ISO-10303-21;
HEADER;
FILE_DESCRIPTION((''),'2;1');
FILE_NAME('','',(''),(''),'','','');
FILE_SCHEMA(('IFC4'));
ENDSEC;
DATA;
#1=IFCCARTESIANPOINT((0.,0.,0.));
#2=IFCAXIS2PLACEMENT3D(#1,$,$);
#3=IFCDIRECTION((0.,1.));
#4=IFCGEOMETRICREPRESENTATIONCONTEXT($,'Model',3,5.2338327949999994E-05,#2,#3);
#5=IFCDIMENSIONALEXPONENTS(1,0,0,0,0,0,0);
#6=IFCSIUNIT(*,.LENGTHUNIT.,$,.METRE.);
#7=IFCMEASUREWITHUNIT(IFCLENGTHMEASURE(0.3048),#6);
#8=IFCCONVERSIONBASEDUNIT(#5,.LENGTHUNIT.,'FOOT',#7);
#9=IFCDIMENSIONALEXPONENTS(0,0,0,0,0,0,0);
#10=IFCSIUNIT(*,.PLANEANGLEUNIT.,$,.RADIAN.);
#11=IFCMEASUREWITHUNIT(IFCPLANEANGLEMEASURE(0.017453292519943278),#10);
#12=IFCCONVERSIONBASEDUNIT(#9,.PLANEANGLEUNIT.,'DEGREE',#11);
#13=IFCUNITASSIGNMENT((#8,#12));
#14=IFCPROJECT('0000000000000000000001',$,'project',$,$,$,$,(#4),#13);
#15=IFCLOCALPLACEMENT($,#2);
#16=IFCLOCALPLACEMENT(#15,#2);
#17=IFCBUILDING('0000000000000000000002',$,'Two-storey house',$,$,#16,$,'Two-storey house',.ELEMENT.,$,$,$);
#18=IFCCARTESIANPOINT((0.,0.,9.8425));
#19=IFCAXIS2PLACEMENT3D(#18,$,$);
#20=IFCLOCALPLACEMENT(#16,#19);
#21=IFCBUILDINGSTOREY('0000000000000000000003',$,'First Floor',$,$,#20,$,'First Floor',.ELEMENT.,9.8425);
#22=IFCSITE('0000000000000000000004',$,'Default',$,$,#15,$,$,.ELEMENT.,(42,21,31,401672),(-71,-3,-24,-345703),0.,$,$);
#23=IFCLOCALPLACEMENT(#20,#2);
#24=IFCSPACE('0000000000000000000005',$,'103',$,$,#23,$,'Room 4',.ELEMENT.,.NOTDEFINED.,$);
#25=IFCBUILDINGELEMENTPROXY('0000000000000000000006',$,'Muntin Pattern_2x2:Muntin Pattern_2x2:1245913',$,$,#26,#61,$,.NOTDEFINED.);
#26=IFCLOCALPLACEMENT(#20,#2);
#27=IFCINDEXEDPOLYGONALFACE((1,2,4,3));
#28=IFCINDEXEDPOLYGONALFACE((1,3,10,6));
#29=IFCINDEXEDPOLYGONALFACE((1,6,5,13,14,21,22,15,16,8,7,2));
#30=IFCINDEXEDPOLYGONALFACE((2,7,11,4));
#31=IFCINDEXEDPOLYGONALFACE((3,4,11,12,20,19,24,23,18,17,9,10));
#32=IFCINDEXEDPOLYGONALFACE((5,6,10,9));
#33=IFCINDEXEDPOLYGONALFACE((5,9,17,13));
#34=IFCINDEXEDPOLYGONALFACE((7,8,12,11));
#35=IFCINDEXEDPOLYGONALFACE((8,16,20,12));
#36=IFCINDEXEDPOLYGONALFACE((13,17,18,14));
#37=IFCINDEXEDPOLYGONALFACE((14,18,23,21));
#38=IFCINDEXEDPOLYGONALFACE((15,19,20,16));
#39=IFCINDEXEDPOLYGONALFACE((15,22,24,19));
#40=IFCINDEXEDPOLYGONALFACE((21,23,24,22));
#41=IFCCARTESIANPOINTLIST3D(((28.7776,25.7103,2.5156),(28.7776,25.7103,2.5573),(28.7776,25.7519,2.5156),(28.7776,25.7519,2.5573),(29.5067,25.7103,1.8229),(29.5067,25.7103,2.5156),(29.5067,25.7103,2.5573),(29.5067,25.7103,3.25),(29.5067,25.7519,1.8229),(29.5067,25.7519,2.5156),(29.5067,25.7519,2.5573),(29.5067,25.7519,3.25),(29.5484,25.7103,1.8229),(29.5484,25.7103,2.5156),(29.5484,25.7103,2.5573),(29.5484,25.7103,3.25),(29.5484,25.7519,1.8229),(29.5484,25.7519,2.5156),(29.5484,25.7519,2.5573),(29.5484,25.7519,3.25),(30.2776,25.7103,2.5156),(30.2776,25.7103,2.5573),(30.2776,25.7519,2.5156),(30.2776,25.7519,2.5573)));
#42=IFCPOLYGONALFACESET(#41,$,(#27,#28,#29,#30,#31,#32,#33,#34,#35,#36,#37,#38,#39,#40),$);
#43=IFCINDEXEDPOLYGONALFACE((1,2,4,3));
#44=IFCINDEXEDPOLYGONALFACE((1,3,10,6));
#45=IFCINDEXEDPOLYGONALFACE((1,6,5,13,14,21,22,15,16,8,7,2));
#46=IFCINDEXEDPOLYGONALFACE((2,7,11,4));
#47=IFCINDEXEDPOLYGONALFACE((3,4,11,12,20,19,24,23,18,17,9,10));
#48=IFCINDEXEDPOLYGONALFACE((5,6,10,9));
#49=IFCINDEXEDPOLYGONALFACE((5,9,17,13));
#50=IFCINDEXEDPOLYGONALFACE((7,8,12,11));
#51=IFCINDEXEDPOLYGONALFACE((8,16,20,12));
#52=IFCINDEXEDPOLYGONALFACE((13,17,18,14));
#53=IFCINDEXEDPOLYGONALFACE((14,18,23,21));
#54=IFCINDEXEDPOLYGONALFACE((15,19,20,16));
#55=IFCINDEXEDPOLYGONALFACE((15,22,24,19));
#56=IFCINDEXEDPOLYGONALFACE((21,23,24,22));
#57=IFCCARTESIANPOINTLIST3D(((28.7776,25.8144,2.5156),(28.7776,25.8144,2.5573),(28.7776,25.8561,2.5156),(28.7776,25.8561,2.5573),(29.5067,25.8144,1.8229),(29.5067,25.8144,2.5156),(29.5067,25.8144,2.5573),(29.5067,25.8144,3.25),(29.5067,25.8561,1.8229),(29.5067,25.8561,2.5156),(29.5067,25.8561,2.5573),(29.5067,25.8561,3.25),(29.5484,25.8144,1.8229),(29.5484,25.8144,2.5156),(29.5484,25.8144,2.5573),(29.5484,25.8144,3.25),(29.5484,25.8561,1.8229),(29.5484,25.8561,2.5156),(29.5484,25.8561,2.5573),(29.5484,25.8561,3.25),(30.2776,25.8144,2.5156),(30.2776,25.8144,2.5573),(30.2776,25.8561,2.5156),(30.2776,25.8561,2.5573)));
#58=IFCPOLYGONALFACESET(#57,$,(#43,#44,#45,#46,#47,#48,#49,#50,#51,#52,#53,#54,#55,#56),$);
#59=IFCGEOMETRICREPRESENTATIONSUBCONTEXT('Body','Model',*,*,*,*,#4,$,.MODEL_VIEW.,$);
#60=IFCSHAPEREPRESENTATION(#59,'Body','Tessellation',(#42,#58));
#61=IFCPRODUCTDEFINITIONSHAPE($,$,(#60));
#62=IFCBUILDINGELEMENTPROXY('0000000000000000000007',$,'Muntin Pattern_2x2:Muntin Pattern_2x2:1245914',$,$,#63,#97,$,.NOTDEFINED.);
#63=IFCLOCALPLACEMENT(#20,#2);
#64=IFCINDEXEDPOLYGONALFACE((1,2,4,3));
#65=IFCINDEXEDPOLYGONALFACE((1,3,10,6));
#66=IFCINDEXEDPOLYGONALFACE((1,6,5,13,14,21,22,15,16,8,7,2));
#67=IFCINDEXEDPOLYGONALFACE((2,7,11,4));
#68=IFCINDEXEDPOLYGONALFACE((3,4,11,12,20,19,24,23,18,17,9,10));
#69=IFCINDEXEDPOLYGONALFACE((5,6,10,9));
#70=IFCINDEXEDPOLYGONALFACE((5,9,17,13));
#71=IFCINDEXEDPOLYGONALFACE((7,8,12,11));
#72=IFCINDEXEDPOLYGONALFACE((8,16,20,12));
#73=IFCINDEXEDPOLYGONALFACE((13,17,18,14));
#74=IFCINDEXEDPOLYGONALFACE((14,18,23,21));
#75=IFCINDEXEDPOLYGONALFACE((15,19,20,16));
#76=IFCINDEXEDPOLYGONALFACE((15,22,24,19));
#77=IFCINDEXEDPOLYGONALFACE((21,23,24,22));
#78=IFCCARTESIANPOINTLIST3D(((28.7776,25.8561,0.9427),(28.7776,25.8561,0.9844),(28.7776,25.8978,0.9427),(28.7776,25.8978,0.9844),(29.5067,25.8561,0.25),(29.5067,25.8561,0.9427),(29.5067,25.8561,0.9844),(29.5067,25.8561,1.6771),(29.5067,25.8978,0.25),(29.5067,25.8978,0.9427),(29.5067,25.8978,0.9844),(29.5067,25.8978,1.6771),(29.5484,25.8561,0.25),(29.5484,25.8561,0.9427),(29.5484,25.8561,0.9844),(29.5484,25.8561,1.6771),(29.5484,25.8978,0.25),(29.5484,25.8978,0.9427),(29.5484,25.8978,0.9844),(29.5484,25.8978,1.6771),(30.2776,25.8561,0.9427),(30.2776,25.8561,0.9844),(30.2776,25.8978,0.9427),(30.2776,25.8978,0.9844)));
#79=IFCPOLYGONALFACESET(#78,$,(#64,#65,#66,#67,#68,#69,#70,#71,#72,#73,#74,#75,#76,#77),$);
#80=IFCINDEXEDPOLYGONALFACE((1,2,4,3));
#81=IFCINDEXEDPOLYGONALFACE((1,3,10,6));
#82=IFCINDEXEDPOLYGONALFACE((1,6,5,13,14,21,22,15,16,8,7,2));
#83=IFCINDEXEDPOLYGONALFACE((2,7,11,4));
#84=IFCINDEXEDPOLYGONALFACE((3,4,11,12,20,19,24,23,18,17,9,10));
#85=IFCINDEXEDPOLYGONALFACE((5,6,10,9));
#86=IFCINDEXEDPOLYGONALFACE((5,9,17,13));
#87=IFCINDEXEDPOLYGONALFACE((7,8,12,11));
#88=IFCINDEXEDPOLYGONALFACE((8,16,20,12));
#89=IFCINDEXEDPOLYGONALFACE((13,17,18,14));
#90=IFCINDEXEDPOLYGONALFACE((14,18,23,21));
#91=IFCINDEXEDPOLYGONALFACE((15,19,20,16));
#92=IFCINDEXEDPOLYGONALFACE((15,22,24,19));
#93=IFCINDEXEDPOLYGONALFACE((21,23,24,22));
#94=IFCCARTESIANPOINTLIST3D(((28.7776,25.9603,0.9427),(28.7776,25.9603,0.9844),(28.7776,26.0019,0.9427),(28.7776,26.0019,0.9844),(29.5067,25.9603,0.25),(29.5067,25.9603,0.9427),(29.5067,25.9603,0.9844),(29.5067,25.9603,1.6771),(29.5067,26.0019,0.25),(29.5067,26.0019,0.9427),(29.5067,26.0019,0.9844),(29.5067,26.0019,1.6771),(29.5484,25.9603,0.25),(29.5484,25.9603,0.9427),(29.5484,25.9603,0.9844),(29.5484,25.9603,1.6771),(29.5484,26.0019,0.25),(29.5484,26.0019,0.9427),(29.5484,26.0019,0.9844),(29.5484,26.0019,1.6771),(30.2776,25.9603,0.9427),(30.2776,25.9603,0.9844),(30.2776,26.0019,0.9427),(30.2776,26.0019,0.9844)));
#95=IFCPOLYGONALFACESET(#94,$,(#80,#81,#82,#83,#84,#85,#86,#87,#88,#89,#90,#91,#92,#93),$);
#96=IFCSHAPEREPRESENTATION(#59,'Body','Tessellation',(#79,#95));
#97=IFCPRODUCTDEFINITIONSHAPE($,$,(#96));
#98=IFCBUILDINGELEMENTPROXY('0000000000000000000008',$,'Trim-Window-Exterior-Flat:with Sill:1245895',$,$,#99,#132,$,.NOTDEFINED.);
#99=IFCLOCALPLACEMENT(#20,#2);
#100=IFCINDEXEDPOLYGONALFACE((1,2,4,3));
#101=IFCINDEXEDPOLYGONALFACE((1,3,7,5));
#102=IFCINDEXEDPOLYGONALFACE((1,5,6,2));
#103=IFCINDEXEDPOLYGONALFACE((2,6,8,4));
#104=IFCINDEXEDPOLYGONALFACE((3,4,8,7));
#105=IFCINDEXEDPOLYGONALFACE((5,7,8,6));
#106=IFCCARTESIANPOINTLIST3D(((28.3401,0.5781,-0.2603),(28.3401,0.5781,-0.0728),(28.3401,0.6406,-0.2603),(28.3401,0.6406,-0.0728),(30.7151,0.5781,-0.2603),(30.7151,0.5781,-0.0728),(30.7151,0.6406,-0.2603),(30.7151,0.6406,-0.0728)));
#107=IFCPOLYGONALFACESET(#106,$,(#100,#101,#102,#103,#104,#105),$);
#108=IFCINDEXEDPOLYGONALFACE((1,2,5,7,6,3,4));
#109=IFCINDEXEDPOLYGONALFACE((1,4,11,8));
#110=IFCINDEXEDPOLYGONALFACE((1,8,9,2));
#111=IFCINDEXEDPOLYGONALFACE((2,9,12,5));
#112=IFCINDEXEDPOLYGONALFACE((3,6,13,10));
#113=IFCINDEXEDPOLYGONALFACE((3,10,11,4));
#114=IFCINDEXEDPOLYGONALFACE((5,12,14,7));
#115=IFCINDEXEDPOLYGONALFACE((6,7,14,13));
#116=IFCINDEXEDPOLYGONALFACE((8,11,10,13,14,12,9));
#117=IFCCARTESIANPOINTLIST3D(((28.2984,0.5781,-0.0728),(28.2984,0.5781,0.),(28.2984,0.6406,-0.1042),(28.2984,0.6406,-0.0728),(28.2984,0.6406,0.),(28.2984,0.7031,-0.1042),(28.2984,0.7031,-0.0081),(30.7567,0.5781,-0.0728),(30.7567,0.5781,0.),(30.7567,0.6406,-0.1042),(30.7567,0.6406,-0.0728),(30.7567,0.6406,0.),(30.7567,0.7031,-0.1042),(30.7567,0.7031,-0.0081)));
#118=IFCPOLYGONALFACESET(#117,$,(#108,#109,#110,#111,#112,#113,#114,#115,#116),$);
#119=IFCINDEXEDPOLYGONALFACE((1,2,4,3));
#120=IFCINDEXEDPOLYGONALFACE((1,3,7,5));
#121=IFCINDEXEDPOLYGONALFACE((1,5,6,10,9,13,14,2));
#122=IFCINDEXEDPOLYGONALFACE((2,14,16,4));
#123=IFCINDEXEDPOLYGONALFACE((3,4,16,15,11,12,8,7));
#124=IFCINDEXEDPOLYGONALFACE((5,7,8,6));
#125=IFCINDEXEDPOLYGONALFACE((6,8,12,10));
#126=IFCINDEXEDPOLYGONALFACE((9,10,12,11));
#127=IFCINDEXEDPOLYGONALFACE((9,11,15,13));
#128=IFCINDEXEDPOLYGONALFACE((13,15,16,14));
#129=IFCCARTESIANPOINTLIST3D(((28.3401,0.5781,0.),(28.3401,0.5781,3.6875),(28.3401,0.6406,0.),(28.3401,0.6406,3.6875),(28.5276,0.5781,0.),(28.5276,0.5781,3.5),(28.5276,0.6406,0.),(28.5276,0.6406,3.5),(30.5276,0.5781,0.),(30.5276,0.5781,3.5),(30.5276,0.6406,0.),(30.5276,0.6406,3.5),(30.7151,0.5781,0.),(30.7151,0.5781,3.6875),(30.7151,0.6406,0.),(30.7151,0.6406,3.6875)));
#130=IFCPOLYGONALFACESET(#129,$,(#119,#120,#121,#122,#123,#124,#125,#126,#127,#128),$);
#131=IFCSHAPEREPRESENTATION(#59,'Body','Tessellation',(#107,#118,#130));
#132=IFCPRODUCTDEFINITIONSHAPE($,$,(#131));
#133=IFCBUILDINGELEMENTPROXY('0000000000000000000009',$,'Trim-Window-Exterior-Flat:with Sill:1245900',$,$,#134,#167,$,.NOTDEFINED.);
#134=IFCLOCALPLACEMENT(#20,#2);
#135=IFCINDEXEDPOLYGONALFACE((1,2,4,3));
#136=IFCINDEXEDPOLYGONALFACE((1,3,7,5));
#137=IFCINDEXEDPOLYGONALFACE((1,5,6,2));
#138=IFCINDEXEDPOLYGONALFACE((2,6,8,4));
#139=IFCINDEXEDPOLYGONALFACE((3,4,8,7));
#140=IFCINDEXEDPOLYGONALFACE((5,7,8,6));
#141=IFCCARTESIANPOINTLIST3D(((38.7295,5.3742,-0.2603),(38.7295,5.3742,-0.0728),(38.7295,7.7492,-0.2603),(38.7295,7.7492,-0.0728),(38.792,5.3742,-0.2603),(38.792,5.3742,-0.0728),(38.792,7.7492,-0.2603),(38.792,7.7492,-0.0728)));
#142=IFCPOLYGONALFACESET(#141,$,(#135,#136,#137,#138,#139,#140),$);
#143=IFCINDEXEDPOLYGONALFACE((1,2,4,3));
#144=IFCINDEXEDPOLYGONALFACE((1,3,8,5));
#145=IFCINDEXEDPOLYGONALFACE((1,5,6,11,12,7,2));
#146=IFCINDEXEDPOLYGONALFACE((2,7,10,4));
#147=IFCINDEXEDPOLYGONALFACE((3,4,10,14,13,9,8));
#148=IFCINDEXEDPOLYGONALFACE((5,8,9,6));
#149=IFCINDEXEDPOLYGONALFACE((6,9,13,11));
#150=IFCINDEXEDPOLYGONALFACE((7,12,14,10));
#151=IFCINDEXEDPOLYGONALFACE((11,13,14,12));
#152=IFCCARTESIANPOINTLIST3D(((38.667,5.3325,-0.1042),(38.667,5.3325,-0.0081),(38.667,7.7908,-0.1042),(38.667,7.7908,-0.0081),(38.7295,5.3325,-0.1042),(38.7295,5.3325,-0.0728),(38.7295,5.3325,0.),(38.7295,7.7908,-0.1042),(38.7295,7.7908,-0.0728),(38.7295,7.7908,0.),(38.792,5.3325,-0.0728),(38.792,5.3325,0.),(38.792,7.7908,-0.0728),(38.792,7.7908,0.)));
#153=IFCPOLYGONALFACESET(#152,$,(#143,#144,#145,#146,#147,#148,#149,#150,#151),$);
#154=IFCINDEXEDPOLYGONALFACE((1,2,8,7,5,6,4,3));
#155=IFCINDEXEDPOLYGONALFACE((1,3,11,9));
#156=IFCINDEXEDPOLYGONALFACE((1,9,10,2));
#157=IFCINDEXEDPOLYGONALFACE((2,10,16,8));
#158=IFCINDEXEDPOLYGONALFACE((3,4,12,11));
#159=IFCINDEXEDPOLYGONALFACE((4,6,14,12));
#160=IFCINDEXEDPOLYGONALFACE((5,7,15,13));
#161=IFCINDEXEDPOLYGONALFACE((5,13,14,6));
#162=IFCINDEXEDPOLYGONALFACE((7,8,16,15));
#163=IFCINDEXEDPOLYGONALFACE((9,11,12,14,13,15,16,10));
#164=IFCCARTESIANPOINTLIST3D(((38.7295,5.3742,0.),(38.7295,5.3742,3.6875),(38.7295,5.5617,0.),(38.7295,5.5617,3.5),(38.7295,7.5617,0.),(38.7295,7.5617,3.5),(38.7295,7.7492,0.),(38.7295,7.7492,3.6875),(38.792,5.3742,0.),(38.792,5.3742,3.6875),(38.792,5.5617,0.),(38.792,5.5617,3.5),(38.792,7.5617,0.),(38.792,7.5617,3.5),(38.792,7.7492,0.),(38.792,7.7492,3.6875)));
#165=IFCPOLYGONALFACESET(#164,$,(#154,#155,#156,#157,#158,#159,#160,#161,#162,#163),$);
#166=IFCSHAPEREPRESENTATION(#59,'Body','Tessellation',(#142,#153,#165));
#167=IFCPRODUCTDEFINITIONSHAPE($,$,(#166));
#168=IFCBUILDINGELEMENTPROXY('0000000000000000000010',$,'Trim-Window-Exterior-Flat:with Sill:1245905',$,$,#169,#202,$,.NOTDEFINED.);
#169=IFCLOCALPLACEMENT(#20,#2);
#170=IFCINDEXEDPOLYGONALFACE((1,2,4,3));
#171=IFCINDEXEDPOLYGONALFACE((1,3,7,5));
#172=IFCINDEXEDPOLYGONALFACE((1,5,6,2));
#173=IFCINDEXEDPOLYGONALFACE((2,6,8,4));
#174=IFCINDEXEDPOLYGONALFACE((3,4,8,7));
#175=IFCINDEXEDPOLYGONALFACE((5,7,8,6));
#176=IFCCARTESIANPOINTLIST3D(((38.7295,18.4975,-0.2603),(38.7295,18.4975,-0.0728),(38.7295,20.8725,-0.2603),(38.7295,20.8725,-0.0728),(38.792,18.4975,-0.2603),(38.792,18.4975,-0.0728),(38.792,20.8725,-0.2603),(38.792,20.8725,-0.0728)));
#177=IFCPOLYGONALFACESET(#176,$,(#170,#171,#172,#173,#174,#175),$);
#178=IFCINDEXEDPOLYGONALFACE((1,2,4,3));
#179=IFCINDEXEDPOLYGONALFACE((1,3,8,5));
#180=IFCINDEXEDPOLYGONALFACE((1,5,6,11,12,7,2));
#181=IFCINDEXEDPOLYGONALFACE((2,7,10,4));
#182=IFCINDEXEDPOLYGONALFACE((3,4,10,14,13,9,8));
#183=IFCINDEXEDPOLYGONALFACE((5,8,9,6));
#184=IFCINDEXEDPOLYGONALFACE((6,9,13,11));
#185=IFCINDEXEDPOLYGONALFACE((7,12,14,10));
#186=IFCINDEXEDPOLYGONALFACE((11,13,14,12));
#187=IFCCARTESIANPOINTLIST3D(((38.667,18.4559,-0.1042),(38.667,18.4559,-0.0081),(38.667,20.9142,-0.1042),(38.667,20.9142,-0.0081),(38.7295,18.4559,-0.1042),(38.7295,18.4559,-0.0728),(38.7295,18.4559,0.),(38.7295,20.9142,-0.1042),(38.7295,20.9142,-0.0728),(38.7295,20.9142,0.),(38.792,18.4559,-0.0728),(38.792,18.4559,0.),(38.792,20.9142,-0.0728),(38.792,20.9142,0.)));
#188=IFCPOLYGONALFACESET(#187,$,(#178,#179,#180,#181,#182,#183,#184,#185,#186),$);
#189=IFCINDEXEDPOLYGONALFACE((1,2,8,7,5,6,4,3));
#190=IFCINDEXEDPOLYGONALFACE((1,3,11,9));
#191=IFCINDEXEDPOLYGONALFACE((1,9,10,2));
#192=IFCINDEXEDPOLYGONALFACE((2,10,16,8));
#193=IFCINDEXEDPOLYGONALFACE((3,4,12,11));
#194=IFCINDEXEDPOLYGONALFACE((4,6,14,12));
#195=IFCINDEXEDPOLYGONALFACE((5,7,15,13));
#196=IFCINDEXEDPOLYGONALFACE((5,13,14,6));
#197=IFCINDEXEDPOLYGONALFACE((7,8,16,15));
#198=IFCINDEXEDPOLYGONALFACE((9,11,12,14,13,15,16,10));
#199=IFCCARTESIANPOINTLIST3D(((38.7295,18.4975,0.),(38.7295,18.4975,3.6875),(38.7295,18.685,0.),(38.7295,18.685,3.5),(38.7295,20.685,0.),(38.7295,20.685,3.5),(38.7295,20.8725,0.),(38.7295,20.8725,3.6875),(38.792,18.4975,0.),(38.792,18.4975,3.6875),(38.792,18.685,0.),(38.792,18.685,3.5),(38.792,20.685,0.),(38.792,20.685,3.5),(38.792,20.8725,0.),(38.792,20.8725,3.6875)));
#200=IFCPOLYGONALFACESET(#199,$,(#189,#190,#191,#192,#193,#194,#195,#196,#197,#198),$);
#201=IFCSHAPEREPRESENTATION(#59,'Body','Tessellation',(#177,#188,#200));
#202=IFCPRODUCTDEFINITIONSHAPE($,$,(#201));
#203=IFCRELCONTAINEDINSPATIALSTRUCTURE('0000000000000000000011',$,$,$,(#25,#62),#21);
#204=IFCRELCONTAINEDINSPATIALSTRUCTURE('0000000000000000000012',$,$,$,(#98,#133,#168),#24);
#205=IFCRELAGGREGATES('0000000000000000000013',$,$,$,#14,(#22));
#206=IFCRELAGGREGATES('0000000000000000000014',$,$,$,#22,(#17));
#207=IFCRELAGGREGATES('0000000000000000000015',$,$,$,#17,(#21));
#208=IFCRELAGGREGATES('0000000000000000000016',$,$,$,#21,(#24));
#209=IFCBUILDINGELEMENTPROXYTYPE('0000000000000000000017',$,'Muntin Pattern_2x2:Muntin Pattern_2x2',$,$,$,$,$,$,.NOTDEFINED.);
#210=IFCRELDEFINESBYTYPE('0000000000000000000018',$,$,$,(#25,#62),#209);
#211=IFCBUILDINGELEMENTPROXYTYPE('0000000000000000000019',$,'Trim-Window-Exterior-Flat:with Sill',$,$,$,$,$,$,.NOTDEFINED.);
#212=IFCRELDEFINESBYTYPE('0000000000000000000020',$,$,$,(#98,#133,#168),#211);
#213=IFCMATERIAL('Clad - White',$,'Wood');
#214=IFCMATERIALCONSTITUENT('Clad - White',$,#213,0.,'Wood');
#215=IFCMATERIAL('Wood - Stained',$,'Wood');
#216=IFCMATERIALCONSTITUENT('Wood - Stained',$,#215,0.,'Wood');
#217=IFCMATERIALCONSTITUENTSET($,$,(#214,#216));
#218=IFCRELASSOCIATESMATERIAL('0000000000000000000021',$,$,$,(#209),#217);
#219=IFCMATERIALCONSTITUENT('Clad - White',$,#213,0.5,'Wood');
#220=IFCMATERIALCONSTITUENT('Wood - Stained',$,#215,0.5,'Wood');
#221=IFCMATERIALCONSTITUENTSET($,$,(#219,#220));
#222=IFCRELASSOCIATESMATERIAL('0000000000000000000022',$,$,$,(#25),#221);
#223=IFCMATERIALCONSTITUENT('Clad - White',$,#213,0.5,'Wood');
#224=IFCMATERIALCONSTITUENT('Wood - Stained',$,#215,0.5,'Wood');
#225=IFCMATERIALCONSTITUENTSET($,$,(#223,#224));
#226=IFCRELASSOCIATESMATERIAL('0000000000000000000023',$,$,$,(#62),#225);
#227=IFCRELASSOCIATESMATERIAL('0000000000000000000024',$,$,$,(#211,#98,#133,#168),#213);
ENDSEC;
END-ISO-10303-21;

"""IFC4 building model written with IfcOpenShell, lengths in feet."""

from ifc_helpers import new_model, entity, si_unit, converted_unit, direction, frame, origin, place, context, subcontext, project, spatial, indexed_curve, outline, extrude, source, transform, mapped, material, constituent, constituent_set, type_object, type_shapes, element, save


model = new_model("IFC4")

# Units and contexts
model_context = context("Model", 3, precision=5.2338327949999994e-05, world=origin(), true_north=direction((0.0, 1.0)))
body_context = subcontext(model_context, "Body", "Model", "MODEL_VIEW")
ifc_project = project(units=[converted_unit("LENGTHUNIT", "FOOT", entity("IfcLengthMeasure", 0.3048), si_unit("LENGTHUNIT", "METRE"), dimensions=[1, 0, 0, 0, 0, 0, 0]), converted_unit("PLANEANGLEUNIT", "DEGREE", entity("IfcPlaneAngleMeasure", 0.017453292519943278), si_unit("PLANEANGLEUNIT", "RADIAN"), dimensions=[0, 0, 0, 0, 0, 0, 0])], contexts=[model_context])

# Site, building, storey
site_placement = place(None, origin())
site = spatial("IfcSite", under=ifc_project, at=site_placement, Name="Default", CompositionType="ELEMENT", RefLatitude=(42, 21, 31, 401672), RefLongitude=(-71, -3, -24, -345703), RefElevation=0.0)
building_placement = place(site_placement, origin())
building = spatial("IfcBuilding", under=site, at=building_placement, Name="Two-storey house", LongName="Two-storey house", CompositionType="ELEMENT")
storey_placement = place(building_placement, frame((0.0, 0.0, 9.8425)))
storey = spatial("IfcBuildingStorey", under=building, at=storey_placement, Name="First Floor", LongName="First Floor", CompositionType="ELEMENT", Elevation=9.8425)

# Shared definitions
ifc_material_1 = material(Name="Wood - Stained", Category="Wood")

# Building element proxies
ifc_material_2 = material(Name="Clad - White", Category="Wood")
ifc_constituent_1 = constituent(ifc_material_2, Name="Clad - White", Category="Wood", fraction=0.0)
ifc_constituent_2 = constituent(ifc_material_1, Name="Wood - Stained", Category="Wood", fraction=0.0)
ifc_constituent_set_1 = constituent_set(constituents=[ifc_constituent_1, ifc_constituent_2])
building_element_proxy_type_1 = type_object("IfcBuildingElementProxyType", Name="Muntin Pattern_2x2:Muntin Pattern_2x2", PredefinedType="NOTDEFINED", material=ifc_constituent_set_1)
shared_shape_1 = source(origin(), body_context, "Body", "SweptSolid", [
    extrude(outline(indexed_curve([(0.0208, -0.0208), (0.7135, -0.0208), (0.7135, 0.0208), (0.0208, 0.0208), (0.0208, 0.75), (-0.0208, 0.75), (-0.0208, 0.0208), (-0.7135, 0.0208), (-0.7135, -0.0208), (-0.0208, -0.0208), (-0.0208, -0.75), (0.0208, -0.75), (0.0208, -0.0208)], self_intersect=False)), frame((0.0, 0.0312, 0.7135), z_axis=(0.0, 1.0, 0.0), x_axis=(0.0, 0.0, 1.0)), (0.0, 0.0, 1.0), 0.0417),
    extrude(outline(indexed_curve([(0.0208, -0.0208), (0.7135, -0.0208), (0.7135, 0.0208), (0.0208, 0.0208), (0.0208, 0.75), (-0.0208, 0.75), (-0.0208, 0.0208), (-0.7135, 0.0208), (-0.7135, -0.0208), (-0.0208, -0.0208), (-0.0208, -0.75), (0.0208, -0.75), (0.0208, -0.0208)], self_intersect=False)), frame((0.0, -0.0729, 0.7135), z_axis=(0.0, 1.0, 0.0), x_axis=(0.0, 0.0, 1.0)), (0.0, 0.0, 1.0), 0.0417),
])
type_shapes(building_element_proxy_type_1, [shared_shape_1])
ifc_constituent_3 = constituent(ifc_material_2, Name="Clad - White", Category="Wood", fraction=0.5)
ifc_constituent_4 = constituent(ifc_material_1, Name="Wood - Stained", Category="Wood", fraction=0.5)
ifc_constituent_set_2 = constituent_set(constituents=[ifc_constituent_3, ifc_constituent_4])
proxy_1_placement = place(storey_placement, frame((29.5276, 25.7832, 1.8229), z_axis=(0.0, 0.0, 1.0), x_axis=(-1.0, 0.0, 0.0)))
element("IfcBuildingElementProxy", 1, at=proxy_1_placement, inside=storey, type_object=building_element_proxy_type_1, material=ifc_constituent_set_2, Name="Muntin Pattern_2x2:Muntin Pattern_2x2:1245913", PredefinedType="NOTDEFINED", context=body_context, shape_type="MappedRepresentation", body=[
    mapped(shared_shape_1, transform((0.0, 0.0, 0.0), scale=1.0)),
])
ifc_constituent_5 = constituent(ifc_material_2, Name="Clad - White", Category="Wood", fraction=0.5)
ifc_constituent_6 = constituent(ifc_material_1, Name="Wood - Stained", Category="Wood", fraction=0.5)
ifc_constituent_set_3 = constituent_set(constituents=[ifc_constituent_5, ifc_constituent_6])
proxy_2_placement = place(storey_placement, frame((29.5276, 25.929, 0.25), z_axis=(0.0, 0.0, 1.0), x_axis=(-1.0, 0.0, 0.0)))
element("IfcBuildingElementProxy", 2, at=proxy_2_placement, inside=storey, type_object=building_element_proxy_type_1, material=ifc_constituent_set_3, Name="Muntin Pattern_2x2:Muntin Pattern_2x2:1245914", PredefinedType="NOTDEFINED", context=body_context, shape_type="MappedRepresentation", body=[
    mapped(shared_shape_1, transform((0.0, 0.0, 0.0), scale=1.0)),
])

# Shared definitions
space_placement = place(storey_placement, origin())
space = spatial("IfcSpace", under=storey, at=space_placement, Name="103", LongName="Room 4", CompositionType="ELEMENT", PredefinedType="NOTDEFINED")

# Building element proxies
building_element_proxy_type_2 = type_object("IfcBuildingElementProxyType", Name="Trim-Window-Exterior-Flat:with Sill", PredefinedType="NOTDEFINED", material=ifc_material_2)
shared_shape_2 = source(origin(), body_context, "Body", "SweptSolid", [
    extrude(outline(indexed_curve([(-1.1875, -0.0938), (1.1875, -0.0938), (1.1875, 0.0938), (-1.1875, 0.0938), (-1.1875, -0.0938)], self_intersect=False)), frame((0.0, -3.6665, 0.0), z_axis=(0.0, 0.0, 1.0), x_axis=(-1.0, 0.0, 0.0)), (0.0, 0.0, 1.0), 0.0625),
    extrude(outline(indexed_curve([(-0.0625, -0.0525), (0.0, -0.0525), (0.0, -0.0211), (0.0625, -0.0211), (0.0625, 0.0517), (0.0, 0.0517), (-0.0625, 0.0436), (-0.0625, -0.0525)], self_intersect=False)), frame((-1.2292, -3.5517, 0.0625), z_axis=(1.0, 0.0, 0.0), x_axis=(0.0, 0.0, -1.0)), (0.0, 0.0, 1.0), 2.4583),
    extrude(outline(indexed_curve([(-1.8906, -1.1875), (1.7969, -1.1875), (1.7969, -1.0), (-1.7031, -1.0), (-1.7031, 1.0), (1.7969, 1.0), (1.7969, 1.1875), (-1.8906, 1.1875), (-1.8906, -1.1875)], self_intersect=False)), frame((0.0, -1.7031, 0.0), z_axis=(0.0, 0.0, 1.0), x_axis=(0.0, -1.0, 0.0)), (0.0, 0.0, 1.0), 0.0625),
])
type_shapes(building_element_proxy_type_2, [shared_shape_2])
for number, where, z_axis, x_axis, name in (
    (3, (29.5276, 0.5781, 3.5), (0.0, 1.0, 0.0), (-1.0, 0.0, 0.0), "Trim-Window-Exterior-Flat:with Sill:1245895"),
    (4, (38.792, 6.5617, 3.5), (-1.0, 0.0, 0.0), (0.0, -1.0, 0.0), "Trim-Window-Exterior-Flat:with Sill:1245900"),
    (5, (38.792, 19.685, 3.5), (-1.0, 0.0, 0.0), (0.0, -1.0, 0.0), "Trim-Window-Exterior-Flat:with Sill:1245905"),
):
    element("IfcBuildingElementProxy", number, at=place(space_placement, frame(where, z_axis=z_axis, x_axis=x_axis)), inside=space, type_object=building_element_proxy_type_2, material=ifc_material_2, Name=name, PredefinedType="NOTDEFINED", context=body_context, shape_type="MappedRepresentation", body=[
        mapped(shared_shape_2, transform((0.0, 0.0, 0.0), scale=1.0)),
    ])

save(model, "model.ifc")
